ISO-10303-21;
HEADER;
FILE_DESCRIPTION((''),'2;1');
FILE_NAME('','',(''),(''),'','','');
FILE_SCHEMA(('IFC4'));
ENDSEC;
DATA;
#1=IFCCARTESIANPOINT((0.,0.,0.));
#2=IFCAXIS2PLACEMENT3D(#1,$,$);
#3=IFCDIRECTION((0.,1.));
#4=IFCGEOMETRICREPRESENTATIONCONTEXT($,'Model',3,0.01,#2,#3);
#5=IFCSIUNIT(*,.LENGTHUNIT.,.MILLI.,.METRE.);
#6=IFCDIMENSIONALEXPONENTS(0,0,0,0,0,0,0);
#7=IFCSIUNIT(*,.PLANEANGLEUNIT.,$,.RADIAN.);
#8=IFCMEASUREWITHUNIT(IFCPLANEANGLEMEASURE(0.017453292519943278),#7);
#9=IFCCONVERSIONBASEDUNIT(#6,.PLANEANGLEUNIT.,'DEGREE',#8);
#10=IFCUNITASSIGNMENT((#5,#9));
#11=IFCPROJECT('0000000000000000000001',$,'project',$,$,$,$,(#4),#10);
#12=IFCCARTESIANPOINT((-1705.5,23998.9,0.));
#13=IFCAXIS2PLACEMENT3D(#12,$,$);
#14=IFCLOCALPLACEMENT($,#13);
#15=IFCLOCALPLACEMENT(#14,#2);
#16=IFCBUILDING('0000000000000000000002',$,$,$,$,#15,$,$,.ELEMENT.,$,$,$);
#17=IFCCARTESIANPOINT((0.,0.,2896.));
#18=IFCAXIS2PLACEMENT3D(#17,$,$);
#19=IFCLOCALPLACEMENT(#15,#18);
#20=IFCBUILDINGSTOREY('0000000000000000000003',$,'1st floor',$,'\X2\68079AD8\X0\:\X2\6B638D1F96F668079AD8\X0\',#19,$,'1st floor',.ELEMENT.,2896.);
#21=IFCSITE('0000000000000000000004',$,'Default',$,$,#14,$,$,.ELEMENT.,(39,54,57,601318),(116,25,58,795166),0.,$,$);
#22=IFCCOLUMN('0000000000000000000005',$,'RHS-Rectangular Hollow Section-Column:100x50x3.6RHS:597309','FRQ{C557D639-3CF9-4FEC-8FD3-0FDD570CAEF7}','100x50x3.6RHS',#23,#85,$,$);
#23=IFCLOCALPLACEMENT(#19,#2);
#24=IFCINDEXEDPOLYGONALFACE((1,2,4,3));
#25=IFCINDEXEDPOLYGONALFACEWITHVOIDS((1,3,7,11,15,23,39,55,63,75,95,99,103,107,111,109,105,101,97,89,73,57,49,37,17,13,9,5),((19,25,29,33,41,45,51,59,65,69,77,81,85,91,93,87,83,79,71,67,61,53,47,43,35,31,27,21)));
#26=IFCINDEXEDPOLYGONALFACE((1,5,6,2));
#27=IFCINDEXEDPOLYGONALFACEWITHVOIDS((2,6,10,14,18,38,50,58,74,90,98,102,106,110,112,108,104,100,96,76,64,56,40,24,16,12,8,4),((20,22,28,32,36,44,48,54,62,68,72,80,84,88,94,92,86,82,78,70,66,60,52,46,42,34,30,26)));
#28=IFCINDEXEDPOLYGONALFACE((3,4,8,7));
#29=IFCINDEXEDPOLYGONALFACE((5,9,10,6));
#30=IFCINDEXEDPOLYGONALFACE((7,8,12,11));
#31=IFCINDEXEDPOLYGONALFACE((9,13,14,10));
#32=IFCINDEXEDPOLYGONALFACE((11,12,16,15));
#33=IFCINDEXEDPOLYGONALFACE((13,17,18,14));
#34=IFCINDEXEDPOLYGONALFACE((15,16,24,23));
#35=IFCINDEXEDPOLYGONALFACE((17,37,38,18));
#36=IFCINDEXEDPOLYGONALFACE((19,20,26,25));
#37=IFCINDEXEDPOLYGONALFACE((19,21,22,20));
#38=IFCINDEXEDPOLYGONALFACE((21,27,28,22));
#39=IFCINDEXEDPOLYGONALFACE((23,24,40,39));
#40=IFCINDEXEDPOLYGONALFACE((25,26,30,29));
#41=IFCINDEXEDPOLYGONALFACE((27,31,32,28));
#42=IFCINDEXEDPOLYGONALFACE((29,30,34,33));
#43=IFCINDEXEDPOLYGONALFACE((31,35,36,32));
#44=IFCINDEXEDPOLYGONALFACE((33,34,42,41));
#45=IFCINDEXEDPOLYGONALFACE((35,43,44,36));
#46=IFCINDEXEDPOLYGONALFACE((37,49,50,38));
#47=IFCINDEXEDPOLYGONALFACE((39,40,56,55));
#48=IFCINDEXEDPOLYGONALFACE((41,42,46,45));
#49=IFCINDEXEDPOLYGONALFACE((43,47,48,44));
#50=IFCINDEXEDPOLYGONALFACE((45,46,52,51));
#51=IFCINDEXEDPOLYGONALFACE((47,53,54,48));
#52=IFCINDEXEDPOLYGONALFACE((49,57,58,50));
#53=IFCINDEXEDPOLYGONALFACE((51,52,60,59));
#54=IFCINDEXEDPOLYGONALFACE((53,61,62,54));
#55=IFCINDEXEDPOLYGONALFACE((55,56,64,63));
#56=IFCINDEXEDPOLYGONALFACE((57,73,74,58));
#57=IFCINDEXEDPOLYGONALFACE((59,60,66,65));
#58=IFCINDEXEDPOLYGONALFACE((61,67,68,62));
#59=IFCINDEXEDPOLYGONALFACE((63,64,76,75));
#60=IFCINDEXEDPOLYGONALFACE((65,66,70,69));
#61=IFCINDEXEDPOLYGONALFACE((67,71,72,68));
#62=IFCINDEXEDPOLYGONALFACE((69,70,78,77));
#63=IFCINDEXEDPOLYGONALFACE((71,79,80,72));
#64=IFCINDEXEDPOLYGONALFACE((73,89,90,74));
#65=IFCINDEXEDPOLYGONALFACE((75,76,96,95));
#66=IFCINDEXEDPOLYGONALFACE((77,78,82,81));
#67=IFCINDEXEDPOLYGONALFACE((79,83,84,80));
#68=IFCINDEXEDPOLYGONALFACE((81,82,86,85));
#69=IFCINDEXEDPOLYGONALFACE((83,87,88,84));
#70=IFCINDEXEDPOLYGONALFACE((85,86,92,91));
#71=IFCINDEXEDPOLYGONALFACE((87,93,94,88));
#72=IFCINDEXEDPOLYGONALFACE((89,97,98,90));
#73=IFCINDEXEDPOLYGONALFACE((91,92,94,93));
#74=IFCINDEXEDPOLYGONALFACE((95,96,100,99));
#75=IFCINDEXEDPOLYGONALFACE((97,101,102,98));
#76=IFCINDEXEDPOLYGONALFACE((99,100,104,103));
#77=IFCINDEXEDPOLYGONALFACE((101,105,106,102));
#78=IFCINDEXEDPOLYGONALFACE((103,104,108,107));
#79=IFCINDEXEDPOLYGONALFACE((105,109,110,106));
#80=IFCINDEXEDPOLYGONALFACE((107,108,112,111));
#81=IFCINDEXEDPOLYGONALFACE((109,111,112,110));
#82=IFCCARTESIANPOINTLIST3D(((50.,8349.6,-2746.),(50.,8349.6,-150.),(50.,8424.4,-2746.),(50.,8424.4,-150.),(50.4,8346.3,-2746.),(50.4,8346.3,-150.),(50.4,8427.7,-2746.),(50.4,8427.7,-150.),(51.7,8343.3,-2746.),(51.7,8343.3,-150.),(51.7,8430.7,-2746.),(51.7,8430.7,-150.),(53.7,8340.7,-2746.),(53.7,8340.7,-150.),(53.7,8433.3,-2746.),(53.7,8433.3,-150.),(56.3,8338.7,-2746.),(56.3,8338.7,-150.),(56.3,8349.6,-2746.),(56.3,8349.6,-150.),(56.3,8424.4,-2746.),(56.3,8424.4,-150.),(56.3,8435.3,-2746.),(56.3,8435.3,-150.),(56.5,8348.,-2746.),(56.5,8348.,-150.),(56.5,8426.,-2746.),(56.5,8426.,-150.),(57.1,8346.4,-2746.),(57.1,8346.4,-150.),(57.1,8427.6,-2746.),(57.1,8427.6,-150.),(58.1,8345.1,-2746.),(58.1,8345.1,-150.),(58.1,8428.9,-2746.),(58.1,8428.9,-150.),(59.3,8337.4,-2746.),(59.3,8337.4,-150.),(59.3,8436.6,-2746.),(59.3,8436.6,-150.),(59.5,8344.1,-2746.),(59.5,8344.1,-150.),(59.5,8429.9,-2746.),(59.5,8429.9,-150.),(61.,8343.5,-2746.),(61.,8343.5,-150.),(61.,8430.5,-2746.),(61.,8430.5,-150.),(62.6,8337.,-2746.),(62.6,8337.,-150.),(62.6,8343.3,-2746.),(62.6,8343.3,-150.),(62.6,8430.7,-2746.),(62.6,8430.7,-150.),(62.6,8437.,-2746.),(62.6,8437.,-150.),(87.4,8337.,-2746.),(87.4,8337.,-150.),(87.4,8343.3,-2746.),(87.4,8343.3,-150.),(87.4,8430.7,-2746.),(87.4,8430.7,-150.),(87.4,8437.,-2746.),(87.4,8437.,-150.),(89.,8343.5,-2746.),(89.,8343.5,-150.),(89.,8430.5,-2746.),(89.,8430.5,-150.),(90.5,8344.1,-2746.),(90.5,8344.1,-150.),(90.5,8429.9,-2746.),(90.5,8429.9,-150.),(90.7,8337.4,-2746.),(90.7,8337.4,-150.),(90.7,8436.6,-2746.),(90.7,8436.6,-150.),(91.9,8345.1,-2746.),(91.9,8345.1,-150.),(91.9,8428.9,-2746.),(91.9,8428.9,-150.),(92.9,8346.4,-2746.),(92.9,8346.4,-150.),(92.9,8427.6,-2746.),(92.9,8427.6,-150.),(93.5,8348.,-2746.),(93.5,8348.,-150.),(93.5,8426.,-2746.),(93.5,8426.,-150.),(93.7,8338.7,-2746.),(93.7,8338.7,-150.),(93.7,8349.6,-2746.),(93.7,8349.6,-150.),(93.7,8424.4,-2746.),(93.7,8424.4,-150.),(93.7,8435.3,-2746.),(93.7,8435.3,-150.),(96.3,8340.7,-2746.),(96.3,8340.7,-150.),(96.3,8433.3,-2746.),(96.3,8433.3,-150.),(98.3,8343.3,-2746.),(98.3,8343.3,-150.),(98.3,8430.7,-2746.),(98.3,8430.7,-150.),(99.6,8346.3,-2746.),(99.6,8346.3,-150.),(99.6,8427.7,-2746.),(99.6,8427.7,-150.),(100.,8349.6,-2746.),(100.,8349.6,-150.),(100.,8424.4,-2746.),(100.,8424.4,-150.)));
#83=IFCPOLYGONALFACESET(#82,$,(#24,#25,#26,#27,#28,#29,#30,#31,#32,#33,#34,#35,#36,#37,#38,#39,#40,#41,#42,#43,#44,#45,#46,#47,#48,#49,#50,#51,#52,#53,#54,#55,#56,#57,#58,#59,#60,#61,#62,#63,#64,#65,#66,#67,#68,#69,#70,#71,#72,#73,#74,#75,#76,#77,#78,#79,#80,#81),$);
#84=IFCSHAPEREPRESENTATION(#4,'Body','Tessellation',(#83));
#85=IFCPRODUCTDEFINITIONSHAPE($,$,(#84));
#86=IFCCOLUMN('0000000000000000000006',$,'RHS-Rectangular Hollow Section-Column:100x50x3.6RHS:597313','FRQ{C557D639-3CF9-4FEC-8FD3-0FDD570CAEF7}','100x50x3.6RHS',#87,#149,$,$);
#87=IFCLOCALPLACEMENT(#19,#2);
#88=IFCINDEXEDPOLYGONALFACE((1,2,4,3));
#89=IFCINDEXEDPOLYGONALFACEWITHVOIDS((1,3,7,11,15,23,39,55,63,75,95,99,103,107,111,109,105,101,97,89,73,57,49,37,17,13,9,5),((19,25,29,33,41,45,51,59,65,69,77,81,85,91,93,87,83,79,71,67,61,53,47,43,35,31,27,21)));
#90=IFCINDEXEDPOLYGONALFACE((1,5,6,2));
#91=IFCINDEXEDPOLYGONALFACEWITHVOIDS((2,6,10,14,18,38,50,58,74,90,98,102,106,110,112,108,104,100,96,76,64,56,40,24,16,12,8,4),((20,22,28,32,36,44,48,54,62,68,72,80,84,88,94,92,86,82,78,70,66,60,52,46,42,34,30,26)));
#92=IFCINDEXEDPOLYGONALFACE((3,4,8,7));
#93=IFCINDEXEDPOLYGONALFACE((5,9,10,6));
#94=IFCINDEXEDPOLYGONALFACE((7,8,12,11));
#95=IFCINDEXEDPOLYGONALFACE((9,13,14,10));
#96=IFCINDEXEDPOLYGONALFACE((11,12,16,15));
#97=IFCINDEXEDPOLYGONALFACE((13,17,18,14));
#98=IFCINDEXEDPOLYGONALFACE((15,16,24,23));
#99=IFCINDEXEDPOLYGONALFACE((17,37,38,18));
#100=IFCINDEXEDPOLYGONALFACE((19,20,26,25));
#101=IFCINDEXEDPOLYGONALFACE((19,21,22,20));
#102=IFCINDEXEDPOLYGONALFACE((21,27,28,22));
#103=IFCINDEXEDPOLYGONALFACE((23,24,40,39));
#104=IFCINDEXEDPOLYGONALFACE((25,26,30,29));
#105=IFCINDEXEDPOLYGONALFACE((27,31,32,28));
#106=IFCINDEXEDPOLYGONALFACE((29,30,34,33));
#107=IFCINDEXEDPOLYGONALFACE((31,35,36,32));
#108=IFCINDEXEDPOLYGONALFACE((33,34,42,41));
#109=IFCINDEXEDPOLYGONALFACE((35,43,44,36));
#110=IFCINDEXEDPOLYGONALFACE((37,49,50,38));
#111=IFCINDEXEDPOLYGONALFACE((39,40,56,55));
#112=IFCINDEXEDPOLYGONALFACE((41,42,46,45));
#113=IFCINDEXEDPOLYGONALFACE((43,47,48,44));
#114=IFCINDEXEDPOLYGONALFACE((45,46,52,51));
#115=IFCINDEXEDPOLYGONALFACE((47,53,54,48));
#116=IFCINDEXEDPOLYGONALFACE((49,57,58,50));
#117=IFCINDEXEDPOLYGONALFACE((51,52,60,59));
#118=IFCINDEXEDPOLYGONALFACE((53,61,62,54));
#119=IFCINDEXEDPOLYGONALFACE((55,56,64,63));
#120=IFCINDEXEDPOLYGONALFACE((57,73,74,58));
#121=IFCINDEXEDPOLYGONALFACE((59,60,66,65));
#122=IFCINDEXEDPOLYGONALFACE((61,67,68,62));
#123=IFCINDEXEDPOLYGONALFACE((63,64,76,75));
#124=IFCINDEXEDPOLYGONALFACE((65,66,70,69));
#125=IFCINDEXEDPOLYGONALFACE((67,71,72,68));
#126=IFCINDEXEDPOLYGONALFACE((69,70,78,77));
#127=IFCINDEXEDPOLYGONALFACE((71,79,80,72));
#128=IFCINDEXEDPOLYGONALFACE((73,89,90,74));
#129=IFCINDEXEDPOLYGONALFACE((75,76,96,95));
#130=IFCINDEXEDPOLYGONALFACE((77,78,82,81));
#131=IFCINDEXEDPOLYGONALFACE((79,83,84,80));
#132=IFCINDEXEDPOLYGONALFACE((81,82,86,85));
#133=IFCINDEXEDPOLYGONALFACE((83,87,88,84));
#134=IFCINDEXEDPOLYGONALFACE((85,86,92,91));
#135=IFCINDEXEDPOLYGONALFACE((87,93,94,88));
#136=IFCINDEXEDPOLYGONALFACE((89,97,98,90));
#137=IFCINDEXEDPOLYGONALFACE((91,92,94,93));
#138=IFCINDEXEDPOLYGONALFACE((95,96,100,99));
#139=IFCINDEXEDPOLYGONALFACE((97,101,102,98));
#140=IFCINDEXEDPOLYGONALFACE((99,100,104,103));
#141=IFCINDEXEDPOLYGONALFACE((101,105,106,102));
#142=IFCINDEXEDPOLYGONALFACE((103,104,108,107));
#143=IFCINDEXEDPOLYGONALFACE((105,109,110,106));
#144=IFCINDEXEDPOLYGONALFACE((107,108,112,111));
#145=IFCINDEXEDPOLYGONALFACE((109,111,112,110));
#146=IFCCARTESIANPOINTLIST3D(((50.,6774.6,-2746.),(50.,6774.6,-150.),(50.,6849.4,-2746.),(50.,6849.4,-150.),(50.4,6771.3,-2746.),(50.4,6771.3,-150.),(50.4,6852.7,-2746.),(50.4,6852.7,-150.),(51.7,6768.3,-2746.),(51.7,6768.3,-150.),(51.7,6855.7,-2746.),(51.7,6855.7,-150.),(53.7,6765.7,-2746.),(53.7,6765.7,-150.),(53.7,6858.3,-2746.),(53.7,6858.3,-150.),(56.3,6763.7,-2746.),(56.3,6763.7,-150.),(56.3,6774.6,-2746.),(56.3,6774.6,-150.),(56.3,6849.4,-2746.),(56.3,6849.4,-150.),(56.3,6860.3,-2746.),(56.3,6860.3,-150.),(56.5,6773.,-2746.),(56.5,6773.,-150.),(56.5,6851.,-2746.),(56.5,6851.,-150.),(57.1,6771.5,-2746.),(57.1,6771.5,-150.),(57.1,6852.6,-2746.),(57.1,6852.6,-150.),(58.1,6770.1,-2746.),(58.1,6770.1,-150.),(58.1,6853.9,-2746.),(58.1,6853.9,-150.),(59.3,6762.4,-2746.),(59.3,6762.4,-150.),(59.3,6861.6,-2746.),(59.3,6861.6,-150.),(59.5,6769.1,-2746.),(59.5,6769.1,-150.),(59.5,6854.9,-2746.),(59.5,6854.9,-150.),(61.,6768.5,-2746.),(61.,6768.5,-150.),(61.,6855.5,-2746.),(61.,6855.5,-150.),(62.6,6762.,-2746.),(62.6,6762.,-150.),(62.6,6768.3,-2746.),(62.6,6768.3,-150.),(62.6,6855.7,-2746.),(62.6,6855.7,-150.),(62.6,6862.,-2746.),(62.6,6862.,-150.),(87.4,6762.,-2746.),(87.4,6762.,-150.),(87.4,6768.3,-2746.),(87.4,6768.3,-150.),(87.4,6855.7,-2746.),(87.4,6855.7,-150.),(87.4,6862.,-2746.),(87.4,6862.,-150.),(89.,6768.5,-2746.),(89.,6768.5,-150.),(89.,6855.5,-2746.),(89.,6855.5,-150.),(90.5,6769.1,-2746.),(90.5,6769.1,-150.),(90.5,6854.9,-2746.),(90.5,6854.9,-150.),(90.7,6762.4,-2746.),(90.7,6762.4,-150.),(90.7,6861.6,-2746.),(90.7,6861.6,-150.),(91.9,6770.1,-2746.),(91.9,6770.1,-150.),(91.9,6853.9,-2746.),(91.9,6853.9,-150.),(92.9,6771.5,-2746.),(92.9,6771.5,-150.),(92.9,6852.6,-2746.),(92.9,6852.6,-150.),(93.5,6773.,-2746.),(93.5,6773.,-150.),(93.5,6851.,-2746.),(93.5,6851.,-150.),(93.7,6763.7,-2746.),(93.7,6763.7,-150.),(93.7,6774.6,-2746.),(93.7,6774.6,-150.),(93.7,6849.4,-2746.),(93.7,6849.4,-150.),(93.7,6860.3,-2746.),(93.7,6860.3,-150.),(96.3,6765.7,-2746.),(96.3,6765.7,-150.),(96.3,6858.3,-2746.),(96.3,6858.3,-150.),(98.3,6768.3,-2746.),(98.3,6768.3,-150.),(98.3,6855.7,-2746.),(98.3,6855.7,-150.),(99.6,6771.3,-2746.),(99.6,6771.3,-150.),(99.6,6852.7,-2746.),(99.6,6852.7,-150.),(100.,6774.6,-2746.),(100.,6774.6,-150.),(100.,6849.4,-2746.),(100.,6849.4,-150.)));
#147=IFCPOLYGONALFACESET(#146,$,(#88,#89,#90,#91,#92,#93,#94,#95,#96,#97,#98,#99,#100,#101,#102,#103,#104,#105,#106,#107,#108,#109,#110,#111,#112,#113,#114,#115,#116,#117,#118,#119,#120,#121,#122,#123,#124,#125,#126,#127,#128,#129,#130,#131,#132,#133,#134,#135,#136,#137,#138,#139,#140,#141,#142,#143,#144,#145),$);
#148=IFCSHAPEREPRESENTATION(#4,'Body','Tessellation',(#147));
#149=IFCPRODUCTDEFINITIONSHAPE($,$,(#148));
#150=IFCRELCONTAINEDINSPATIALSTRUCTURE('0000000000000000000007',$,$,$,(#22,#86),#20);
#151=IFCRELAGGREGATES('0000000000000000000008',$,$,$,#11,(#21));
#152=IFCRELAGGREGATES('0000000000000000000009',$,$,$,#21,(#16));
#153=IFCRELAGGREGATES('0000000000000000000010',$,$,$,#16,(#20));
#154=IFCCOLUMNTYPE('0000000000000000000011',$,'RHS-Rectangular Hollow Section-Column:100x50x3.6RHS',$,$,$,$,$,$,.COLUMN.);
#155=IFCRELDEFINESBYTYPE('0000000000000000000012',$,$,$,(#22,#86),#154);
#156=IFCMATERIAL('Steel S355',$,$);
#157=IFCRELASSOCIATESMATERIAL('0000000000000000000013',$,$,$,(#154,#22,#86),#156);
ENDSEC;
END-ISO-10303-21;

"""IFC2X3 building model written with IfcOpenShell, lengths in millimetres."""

from ifc_helpers import new_model, entity, si_unit, converted_unit, point, direction, frame, frame_2d, origin, origin_2d, place, context, project, spatial, circle_curve, line_curve, trimmed, segment, composite_curve, hollow_rectangle, outline, extrude, clip, halfspace, material, type_object, element, save


model = new_model("IFC2X3")

# Units and contexts
model_context = context("Model", 3, precision=0.01, world=origin(), true_north=direction((0.0, 1.0)))
ifc_project = project(units=[si_unit("LENGTHUNIT", "METRE", prefix="MILLI"), converted_unit("PLANEANGLEUNIT", "DEGREE", entity("IfcPlaneAngleMeasure", 0.017453292519943278), si_unit("PLANEANGLEUNIT", "RADIAN"), dimensions=[0, 0, 0, 0, 0, 0, 0])], contexts=[model_context])

# Site, building, storey
site_placement = place(None, frame((-1705.5, 23998.9, 0.0)))
site = spatial("IfcSite", under=ifc_project, at=site_placement, Name="Default", CompositionType="ELEMENT", RefLatitude=(39, 54, 57, 601318), RefLongitude=(116, 25, 58, 795166), RefElevation=0.0)
building_placement = place(site_placement, origin())
building = spatial("IfcBuilding", under=site, at=building_placement, CompositionType="ELEMENT")
storey_placement = place(building_placement, frame((0.0, 0.0, 2896.0)))
storey = spatial("IfcBuildingStorey", under=building, at=storey_placement, Name="1st floor", ObjectType="标高:正负零标高", LongName="1st floor", CompositionType="ELEMENT", Elevation=2896.0)

# Columns, openings
ifc_material_1 = material(Name="Steel S355")
column_type_1 = type_object("IfcColumnType", Name="RHS-Rectangular Hollow Section-Column:100x50x3.6RHS", PredefinedType="COLUMN", material=ifc_material_1)
column_1_placement = place(storey_placement, frame((75.0, 8387.0, -19.1)))
column_1 = element("IfcColumn", 1, at=column_1_placement, inside=storey, type_object=column_type_1, material=ifc_material_1, Name="RHS-Rectangular Hollow Section-Column:100x50x3.6RHS:597309", Description="FRQ{C557D639-3CF9-4FEC-8FD3-0FDD570CAEF7}", ObjectType="100x50x3.6RHS", context=model_context, shape_type="Clipping", body=[
    clip(clip(extrude(hollow_rectangle(XDim=50.0, YDim=100.0, WallThickness=6.3, InnerFilletRadius=6.3, OuterFilletRadius=12.6, at=origin_2d()), origin(), (0.0, 0.0, -1.0), 2782.8), halfspace(frame((-75.0, -8387.0, -2726.9), z_axis=(0.0, 0.0, 1.0), x_axis=(1.0, 0.0, 0.0)), True)), halfspace(frame((-75.0, -8387.0, -55.9), z_axis=(0.0, 0.0, -1.0), x_axis=(-1.0, 0.0, 0.0)), True)),
])
opening_1_placement = place(column_1_placement, frame((0.0, -150.1, -130.9), z_axis=(0.0, 1.0, 0.0), x_axis=(-1.0, 0.0, 0.0)))
element("IfcOpeningElement", 2, at=opening_1_placement, cuts=column_1, ObjectType="Opening", context=model_context, shape_type="SweptSolid", body=[
    extrude(outline(composite_curve([segment(trimmed(circle_curve(frame_2d((43.0, 32.0), x_axis=(1.0, 0.0)), 32.0), [point((43.0, 0.0))], [point((75.0, 32.0))], True, "CARTESIAN"), True, "CONTINUOUS"), segment(trimmed(line_curve((75.0, 32.0), (0.0, 1.0), 86.0), [point((75.0, 32.0))], [point((75.0, 118.0))], True, "CARTESIAN"), True, "CONTINUOUS"), segment(trimmed(circle_curve(frame_2d((43.0, 118.0), x_axis=(1.0, 0.0)), 32.0), [point((75.0, 118.0))], [point((43.0, 150.0))], True, "CARTESIAN"), True, "CONTINUOUS"), segment(trimmed(line_curve((43.0, 150.0), (-1.0, 0.0), 86.0), [point((43.0, 150.0))], [point((-43.0, 150.0))], True, "CARTESIAN"), True, "CONTINUOUS"), segment(trimmed(circle_curve(frame_2d((-43.0, 118.0), x_axis=(1.0, 0.0)), 32.0), [point((-43.0, 150.0))], [point((-75.0, 118.0))], True, "CARTESIAN"), True, "CONTINUOUS"), segment(trimmed(line_curve((-75.0, 118.0), (0.0, -1.0), 86.0), [point((-75.0, 118.0))], [point((-75.0, 32.0))], True, "CARTESIAN"), True, "CONTINUOUS"), segment(trimmed(circle_curve(frame_2d((-43.0, 32.0), x_axis=(1.0, 0.0)), 32.0), [point((-75.0, 32.0))], [point((-43.0, 0.0))], True, "CARTESIAN"), True, "CONTINUOUS"), segment(trimmed(line_curve((-43.0, 0.0), (1.0, 0.0), 86.0), [point((-43.0, 0.0))], [point((43.0, 0.0))], True, "CARTESIAN"), True, "CONTINUOUS")], self_intersect="UNKNOWN")), origin(), (0.0, 0.0, 1.0), 300.2),
])
column_2_placement = place(storey_placement, frame((75.0, 6812.0, -19.1)))
column_2 = element("IfcColumn", 3, at=column_2_placement, inside=storey, type_object=column_type_1, material=ifc_material_1, Name="RHS-Rectangular Hollow Section-Column:100x50x3.6RHS:597313", Description="FRQ{C557D639-3CF9-4FEC-8FD3-0FDD570CAEF7}", ObjectType="100x50x3.6RHS", context=model_context, shape_type="Clipping", body=[
    clip(clip(extrude(hollow_rectangle(XDim=50.0, YDim=100.0, WallThickness=6.3, InnerFilletRadius=6.3, OuterFilletRadius=12.6, at=origin_2d()), origin(), (0.0, 0.0, -1.0), 2782.8), halfspace(frame((-75.0, -6812.0, -2726.9), z_axis=(0.0, 0.0, 1.0), x_axis=(1.0, 0.0, 0.0)), True)), halfspace(frame((-75.0, -6812.0, -55.9), z_axis=(0.0, 0.0, -1.0), x_axis=(-1.0, 0.0, 0.0)), True)),
])
opening_2_placement = place(column_2_placement, frame((0.0, -150.1, -130.9), z_axis=(0.0, 1.0, 0.0), x_axis=(-1.0, 0.0, 0.0)))
element("IfcOpeningElement", 4, at=opening_2_placement, cuts=column_2, ObjectType="Opening", context=model_context, shape_type="SweptSolid", body=[
    extrude(outline(composite_curve([segment(trimmed(circle_curve(frame_2d((43.0, 32.0), x_axis=(1.0, 0.0)), 32.0), [point((43.0, 0.0))], [point((75.0, 32.0))], True, "CARTESIAN"), True, "CONTINUOUS"), segment(trimmed(line_curve((75.0, 32.0), (0.0, 1.0), 86.0), [point((75.0, 32.0))], [point((75.0, 118.0))], True, "CARTESIAN"), True, "CONTINUOUS"), segment(trimmed(circle_curve(frame_2d((43.0, 118.0), x_axis=(1.0, 0.0)), 32.0), [point((75.0, 118.0))], [point((43.0, 150.0))], True, "CARTESIAN"), True, "CONTINUOUS"), segment(trimmed(line_curve((43.0, 150.0), (-1.0, 0.0), 86.0), [point((43.0, 150.0))], [point((-43.0, 150.0))], True, "CARTESIAN"), True, "CONTINUOUS"), segment(trimmed(circle_curve(frame_2d((-43.0, 118.0), x_axis=(1.0, 0.0)), 32.0), [point((-43.0, 150.0))], [point((-75.0, 118.0))], True, "CARTESIAN"), True, "CONTINUOUS"), segment(trimmed(line_curve((-75.0, 118.0), (0.0, -1.0), 86.0), [point((-75.0, 118.0))], [point((-75.0, 32.0))], True, "CARTESIAN"), True, "CONTINUOUS"), segment(trimmed(circle_curve(frame_2d((-43.0, 32.0), x_axis=(1.0, 0.0)), 32.0), [point((-75.0, 32.0))], [point((-43.0, 0.0))], True, "CARTESIAN"), True, "CONTINUOUS"), segment(trimmed(line_curve((-43.0, 0.0), (1.0, 0.0), 86.0), [point((-43.0, 0.0))], [point((43.0, 0.0))], True, "CARTESIAN"), True, "CONTINUOUS")], self_intersect="UNKNOWN")), origin(), (0.0, 0.0, 1.0), 300.2),
])

save(model, "model.ifc")
